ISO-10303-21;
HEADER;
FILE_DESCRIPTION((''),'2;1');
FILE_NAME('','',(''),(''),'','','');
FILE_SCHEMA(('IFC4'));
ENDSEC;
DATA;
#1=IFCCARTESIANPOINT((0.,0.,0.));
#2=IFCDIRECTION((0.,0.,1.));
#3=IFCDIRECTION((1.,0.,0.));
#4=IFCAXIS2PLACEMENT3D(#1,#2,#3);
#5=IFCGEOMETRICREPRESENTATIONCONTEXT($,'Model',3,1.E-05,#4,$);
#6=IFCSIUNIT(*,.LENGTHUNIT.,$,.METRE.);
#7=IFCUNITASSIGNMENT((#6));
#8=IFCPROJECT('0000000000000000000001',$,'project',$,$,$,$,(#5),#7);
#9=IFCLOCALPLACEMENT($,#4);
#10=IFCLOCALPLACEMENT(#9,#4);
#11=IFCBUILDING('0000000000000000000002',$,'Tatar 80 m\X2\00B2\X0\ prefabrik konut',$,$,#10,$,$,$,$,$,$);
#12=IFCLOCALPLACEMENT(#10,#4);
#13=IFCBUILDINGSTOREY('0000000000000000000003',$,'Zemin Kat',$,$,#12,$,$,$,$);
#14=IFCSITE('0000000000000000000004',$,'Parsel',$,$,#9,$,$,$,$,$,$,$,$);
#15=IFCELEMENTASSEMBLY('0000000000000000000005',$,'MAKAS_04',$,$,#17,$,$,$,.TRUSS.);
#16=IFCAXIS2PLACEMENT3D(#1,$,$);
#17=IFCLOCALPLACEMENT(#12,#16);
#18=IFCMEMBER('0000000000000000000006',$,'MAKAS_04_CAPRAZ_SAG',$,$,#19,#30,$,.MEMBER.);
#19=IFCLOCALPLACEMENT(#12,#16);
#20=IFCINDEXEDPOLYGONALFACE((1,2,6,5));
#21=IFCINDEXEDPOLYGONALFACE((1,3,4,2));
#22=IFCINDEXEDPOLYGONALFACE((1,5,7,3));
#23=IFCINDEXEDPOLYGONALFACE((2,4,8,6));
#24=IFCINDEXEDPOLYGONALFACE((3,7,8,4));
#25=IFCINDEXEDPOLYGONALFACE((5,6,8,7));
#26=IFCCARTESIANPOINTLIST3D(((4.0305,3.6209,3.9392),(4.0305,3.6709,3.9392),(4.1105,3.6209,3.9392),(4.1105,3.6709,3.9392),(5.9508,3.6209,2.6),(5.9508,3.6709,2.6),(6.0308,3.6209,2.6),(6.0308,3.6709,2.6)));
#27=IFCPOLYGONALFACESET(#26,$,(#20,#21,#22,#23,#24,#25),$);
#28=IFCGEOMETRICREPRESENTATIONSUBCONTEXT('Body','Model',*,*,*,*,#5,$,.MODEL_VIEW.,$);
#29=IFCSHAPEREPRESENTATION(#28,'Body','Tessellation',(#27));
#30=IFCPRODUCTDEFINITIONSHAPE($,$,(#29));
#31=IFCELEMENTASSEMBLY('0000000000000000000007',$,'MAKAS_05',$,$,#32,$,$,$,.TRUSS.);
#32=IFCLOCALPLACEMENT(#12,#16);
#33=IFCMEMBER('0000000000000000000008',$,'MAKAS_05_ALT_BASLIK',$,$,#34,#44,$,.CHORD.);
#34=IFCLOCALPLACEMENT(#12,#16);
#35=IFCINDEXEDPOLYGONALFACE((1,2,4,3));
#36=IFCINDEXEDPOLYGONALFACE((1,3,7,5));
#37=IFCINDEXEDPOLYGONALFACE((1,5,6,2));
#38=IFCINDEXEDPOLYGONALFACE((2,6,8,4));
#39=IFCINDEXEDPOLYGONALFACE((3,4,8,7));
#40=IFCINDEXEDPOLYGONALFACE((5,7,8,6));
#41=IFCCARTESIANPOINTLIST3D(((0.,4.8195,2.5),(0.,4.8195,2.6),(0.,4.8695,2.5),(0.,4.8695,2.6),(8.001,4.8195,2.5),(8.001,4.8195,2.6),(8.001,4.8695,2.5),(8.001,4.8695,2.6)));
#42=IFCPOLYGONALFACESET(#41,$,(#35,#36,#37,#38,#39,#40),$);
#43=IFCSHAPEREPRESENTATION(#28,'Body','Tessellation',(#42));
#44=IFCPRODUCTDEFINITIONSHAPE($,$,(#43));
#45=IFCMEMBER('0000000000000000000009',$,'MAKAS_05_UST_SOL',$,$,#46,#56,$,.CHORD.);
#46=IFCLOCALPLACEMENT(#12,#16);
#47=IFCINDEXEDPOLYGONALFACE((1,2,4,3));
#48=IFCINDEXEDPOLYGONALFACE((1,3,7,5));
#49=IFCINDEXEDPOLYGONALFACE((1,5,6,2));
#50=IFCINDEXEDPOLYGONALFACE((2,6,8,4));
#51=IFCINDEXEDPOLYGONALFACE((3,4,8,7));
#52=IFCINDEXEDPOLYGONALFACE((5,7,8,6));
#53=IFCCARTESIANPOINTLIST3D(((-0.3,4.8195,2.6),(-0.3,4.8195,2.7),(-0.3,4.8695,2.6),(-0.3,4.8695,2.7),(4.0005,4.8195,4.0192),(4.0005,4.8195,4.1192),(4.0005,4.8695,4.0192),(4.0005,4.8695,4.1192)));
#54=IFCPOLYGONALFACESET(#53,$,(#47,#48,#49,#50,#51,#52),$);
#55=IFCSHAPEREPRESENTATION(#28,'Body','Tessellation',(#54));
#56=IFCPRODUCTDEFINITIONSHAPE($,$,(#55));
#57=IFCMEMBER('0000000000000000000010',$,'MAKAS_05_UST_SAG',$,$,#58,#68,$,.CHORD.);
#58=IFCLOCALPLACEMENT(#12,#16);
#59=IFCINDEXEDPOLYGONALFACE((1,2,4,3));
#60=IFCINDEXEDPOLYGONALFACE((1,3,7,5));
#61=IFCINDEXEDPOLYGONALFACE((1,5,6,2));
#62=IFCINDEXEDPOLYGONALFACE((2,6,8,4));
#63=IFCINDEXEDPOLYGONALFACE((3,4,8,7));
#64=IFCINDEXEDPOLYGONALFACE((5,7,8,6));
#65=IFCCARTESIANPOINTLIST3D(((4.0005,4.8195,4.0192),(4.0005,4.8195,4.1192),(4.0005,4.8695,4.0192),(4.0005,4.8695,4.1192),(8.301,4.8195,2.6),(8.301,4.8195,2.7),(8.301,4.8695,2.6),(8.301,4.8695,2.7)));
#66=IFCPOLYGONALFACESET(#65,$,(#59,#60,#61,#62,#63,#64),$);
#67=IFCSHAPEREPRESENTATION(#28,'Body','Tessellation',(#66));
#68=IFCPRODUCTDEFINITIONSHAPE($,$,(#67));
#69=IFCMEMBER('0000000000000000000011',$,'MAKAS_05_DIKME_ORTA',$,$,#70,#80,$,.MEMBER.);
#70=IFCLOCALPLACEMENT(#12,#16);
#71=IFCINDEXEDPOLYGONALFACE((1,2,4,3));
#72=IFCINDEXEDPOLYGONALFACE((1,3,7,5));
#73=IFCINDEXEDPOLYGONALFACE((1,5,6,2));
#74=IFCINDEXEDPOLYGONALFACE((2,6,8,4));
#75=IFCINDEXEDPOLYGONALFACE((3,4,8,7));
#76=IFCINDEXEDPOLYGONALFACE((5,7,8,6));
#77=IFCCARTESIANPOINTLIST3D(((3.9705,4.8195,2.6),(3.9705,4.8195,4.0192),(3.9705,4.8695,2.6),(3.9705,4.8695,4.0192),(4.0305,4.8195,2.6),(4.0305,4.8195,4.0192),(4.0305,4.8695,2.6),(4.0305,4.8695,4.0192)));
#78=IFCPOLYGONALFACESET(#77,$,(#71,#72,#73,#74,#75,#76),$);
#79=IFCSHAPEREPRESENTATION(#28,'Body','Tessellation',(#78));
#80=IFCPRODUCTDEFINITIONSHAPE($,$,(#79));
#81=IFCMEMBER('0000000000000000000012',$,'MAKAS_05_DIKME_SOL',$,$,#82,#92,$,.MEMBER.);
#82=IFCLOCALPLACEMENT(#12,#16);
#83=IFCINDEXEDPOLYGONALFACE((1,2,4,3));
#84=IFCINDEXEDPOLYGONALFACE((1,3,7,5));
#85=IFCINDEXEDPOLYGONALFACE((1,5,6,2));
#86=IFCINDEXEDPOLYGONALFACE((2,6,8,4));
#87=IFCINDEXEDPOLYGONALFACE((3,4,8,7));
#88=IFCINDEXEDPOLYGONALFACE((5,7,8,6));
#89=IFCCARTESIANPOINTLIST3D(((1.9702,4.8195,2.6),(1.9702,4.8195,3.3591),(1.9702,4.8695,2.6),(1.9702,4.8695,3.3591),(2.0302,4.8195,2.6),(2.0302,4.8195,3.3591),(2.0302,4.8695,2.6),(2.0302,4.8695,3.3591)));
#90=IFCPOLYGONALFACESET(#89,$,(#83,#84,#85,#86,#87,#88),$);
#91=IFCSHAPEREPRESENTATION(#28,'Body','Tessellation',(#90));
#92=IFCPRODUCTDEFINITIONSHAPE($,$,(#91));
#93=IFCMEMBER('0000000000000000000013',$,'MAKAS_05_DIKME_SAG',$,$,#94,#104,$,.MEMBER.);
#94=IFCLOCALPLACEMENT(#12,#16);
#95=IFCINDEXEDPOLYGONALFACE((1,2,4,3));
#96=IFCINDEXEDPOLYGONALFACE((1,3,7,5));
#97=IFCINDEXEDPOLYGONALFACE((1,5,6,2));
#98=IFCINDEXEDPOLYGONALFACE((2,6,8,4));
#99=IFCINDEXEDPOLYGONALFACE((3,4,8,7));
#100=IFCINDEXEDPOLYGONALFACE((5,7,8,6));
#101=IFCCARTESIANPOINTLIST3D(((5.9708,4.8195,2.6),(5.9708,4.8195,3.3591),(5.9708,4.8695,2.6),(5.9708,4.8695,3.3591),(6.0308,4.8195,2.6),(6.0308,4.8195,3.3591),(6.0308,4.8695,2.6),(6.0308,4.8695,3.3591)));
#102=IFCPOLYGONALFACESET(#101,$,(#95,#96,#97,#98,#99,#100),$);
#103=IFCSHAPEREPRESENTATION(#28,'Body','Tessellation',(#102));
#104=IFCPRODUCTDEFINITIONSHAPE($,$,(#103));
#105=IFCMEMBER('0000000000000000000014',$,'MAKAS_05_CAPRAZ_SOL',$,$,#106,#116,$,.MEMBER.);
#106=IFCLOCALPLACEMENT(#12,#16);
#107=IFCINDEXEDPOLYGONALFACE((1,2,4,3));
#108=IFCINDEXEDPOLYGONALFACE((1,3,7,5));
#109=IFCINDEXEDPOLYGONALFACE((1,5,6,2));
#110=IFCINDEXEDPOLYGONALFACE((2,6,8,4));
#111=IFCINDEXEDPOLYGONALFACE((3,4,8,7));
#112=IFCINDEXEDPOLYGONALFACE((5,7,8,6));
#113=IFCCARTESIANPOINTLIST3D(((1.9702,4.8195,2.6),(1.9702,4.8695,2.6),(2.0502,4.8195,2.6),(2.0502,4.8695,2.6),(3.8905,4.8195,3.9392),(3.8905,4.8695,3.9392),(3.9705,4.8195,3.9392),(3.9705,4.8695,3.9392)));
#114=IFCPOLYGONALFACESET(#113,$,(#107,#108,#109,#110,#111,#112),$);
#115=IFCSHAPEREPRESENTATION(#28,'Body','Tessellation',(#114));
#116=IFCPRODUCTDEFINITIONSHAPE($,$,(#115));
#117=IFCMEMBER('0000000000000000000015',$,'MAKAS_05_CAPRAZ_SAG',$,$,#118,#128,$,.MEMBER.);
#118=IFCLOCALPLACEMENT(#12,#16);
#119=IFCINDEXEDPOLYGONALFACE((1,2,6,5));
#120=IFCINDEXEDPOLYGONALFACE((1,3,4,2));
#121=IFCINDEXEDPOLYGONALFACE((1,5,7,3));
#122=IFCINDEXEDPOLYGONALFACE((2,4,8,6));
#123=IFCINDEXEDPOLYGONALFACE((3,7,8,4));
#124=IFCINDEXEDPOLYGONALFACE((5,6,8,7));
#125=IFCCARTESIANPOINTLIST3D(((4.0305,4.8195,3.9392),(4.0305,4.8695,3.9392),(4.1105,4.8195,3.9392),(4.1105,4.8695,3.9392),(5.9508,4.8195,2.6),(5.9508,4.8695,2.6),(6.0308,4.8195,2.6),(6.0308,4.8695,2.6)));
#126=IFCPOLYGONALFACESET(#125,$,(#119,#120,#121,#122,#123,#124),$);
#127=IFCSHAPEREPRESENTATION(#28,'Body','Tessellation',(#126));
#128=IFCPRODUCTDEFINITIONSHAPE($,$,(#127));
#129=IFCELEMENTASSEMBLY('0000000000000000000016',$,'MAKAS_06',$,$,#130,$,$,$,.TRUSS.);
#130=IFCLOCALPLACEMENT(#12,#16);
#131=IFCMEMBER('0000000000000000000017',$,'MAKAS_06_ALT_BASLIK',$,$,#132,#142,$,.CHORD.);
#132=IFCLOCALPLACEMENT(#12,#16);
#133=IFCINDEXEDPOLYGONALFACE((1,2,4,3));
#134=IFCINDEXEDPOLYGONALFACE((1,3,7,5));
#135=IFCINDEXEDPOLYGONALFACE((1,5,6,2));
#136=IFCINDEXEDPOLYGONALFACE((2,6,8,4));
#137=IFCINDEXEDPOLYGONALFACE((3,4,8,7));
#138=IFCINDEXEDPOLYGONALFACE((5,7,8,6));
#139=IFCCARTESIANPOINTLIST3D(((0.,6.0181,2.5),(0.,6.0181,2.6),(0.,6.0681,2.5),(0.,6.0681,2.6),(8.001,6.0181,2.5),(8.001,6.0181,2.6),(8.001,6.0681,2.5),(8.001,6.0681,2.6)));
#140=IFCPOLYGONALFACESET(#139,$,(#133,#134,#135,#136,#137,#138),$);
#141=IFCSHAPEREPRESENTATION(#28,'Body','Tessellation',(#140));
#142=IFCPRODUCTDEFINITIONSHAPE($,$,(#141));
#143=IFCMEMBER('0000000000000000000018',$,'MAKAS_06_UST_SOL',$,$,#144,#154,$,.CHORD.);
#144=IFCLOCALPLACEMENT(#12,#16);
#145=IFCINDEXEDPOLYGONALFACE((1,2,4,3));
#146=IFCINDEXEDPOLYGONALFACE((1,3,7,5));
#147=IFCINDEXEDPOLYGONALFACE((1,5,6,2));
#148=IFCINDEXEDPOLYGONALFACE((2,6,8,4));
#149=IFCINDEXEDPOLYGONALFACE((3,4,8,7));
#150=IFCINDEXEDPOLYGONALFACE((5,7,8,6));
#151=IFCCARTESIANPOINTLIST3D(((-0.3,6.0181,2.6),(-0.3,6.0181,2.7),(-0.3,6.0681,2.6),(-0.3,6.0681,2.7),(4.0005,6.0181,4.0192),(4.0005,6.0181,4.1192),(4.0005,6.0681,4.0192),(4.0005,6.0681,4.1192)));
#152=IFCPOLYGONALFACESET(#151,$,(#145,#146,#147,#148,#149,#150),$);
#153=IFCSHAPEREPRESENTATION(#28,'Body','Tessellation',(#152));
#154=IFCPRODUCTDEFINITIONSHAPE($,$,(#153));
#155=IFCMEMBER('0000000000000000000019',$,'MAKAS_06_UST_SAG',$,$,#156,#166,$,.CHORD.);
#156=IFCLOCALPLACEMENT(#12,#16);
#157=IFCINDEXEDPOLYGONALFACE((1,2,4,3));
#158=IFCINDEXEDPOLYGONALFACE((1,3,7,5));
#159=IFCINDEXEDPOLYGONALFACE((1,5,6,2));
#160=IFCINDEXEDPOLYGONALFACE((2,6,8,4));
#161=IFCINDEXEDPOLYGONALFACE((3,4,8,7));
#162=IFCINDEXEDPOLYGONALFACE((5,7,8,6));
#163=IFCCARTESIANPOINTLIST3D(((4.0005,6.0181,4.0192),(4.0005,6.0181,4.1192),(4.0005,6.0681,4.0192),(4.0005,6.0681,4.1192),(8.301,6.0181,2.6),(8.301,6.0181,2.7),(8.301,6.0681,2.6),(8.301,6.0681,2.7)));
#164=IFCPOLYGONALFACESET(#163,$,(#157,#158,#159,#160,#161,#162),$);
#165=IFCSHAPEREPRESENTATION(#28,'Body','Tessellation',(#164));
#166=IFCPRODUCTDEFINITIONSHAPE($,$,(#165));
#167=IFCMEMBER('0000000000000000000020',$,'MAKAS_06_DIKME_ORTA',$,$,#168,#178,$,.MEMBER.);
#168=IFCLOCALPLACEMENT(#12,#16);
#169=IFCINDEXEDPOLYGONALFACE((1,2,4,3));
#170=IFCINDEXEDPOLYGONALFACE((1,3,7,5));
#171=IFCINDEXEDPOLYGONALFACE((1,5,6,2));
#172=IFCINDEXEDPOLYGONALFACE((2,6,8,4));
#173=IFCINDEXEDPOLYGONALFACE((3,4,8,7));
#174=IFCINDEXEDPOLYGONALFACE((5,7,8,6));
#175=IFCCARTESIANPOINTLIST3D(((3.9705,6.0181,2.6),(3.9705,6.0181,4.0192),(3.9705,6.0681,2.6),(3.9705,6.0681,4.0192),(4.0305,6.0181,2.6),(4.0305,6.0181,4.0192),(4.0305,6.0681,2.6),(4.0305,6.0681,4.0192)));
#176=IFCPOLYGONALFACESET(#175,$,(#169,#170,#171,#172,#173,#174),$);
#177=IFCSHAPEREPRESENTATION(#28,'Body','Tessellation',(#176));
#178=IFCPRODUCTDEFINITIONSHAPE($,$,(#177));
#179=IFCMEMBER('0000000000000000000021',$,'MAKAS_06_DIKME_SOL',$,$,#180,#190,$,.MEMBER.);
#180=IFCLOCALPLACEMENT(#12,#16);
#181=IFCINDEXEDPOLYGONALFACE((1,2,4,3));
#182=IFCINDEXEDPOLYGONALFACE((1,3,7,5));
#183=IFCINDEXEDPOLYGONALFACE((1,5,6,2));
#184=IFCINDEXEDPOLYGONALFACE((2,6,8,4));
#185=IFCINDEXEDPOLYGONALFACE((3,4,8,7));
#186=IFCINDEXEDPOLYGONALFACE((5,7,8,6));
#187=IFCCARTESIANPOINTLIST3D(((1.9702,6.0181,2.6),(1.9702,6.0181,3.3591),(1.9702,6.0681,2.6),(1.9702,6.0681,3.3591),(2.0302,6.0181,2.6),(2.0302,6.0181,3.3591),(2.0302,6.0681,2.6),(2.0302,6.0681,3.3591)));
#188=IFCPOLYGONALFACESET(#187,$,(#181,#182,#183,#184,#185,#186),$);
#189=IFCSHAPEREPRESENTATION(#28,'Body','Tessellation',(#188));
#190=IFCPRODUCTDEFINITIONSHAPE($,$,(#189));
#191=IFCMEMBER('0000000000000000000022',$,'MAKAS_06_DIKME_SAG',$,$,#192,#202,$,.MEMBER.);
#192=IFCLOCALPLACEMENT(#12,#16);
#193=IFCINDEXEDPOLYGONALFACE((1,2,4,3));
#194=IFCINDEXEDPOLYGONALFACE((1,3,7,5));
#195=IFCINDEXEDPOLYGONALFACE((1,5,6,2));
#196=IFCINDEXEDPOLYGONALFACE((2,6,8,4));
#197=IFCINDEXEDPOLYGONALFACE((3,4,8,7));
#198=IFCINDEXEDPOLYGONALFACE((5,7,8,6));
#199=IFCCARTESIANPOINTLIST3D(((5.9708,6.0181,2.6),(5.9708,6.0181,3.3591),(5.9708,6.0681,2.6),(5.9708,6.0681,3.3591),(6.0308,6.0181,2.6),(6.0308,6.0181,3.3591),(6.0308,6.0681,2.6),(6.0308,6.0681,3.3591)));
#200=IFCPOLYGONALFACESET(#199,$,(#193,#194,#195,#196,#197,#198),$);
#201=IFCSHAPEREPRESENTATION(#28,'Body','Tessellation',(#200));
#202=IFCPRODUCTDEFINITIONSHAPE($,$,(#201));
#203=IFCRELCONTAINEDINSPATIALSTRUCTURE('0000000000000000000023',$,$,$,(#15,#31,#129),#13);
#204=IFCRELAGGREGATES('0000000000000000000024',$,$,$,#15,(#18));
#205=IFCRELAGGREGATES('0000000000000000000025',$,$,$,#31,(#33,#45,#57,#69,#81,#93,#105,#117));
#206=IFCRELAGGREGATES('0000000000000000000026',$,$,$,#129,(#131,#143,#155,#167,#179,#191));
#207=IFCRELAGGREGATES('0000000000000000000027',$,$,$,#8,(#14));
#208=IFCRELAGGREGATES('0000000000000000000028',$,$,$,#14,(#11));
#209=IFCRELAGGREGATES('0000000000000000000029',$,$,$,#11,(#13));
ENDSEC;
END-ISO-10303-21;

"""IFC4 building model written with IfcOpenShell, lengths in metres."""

from ifc_helpers import new_model, si_unit, frame, origin_with_axes, place, context, subcontext, project, spatial, line, indexed_curve, outline, extrude, element, aggregate, save


model = new_model("IFC4")

# Units and contexts
model_context = context("Model", 3, precision=1e-05, world=origin_with_axes())
body_context = subcontext(model_context, "Body", "Model", "MODEL_VIEW")
ifc_project = project(units=[si_unit("LENGTHUNIT", "METRE")], contexts=[model_context])

# Site, building, storey
site_placement = place(None, origin_with_axes())
site = spatial("IfcSite", under=ifc_project, at=site_placement, Name="Parsel")
building_placement = place(site_placement, origin_with_axes())
building = spatial("IfcBuilding", under=site, at=building_placement, Name="Tatar 80 m² prefabrik konut")
storey_placement = place(building_placement, origin_with_axes())
storey = spatial("IfcBuildingStorey", under=building, at=storey_placement, Name="Zemin Kat")

# Element assembly, member
assembly_1_placement = place(storey_placement, origin_with_axes())
assembly_1 = element("IfcElementAssembly", 1, at=assembly_1_placement, inside=storey, Name="MAKAS_04", PredefinedType="TRUSS")
member_1_placement = place(assembly_1_placement, origin_with_axes())
member_1 = element("IfcMember", 2, at=member_1_placement, Name="MAKAS_04_CAPRAZ_SAG", PredefinedType="MEMBER", context=body_context, shape_type="SweptSolid", body=[
    extrude(outline(indexed_curve([(5.9508, 2.6), (6.0308, 2.6), (4.1105, 3.9392), (4.0305, 3.9392)], segments=[line(1, 2, 3, 4, 1)])), frame((0.0, 3.6709, 0.0), z_axis=(0.0, -1.0, 0.0), x_axis=(1.0, 0.0, 0.0)), (0.0, 0.0, 1.0), 0.05),
])
aggregate(assembly_1, [member_1])

# Element assemblies, members
assembly_2_placement = place(storey_placement, origin_with_axes())
assembly_2 = element("IfcElementAssembly", 3, at=assembly_2_placement, inside=storey, Name="MAKAS_05", PredefinedType="TRUSS")
member_2_placement = place(assembly_2_placement, origin_with_axes())
member_2 = element("IfcMember", 4, at=member_2_placement, Name="MAKAS_05_ALT_BASLIK", PredefinedType="CHORD", context=body_context, shape_type="SweptSolid", body=[
    extrude(outline(indexed_curve([(0.0, 2.5), (8.001, 2.5), (8.001, 2.6), (0.0, 2.6)], segments=[line(1, 2, 3, 4, 1)])), frame((0.0, 4.8695, 0.0), z_axis=(0.0, -1.0, 0.0), x_axis=(1.0, 0.0, 0.0)), (0.0, 0.0, 1.0), 0.05),
])
member_3_placement = place(assembly_2_placement, origin_with_axes())
member_3 = element("IfcMember", 5, at=member_3_placement, Name="MAKAS_05_UST_SOL", PredefinedType="CHORD", context=body_context, shape_type="SweptSolid", body=[
    extrude(outline(indexed_curve([(-0.3, 2.6), (4.0005, 4.0192), (4.0005, 4.1192), (-0.3, 2.7)], segments=[line(1, 2, 3, 4, 1)])), frame((0.0, 4.8695, 0.0), z_axis=(0.0, -1.0, 0.0), x_axis=(1.0, 0.0, 0.0)), (0.0, 0.0, 1.0), 0.05),
])
member_4_placement = place(assembly_2_placement, origin_with_axes())
member_4 = element("IfcMember", 6, at=member_4_placement, Name="MAKAS_05_UST_SAG", PredefinedType="CHORD", context=body_context, shape_type="SweptSolid", body=[
    extrude(outline(indexed_curve([(4.0005, 4.0192), (8.301, 2.6), (8.301, 2.7), (4.0005, 4.1192)], segments=[line(1, 2, 3, 4, 1)])), frame((0.0, 4.8695, 0.0), z_axis=(0.0, -1.0, 0.0), x_axis=(1.0, 0.0, 0.0)), (0.0, 0.0, 1.0), 0.05),
])
member_5_placement = place(assembly_2_placement, origin_with_axes())
member_5 = element("IfcMember", 7, at=member_5_placement, Name="MAKAS_05_DIKME_ORTA", PredefinedType="MEMBER", context=body_context, shape_type="SweptSolid", body=[
    extrude(outline(indexed_curve([(3.9705, 2.6), (4.0305, 2.6), (4.0305, 4.0192), (3.9705, 4.0192)], segments=[line(1, 2, 3, 4, 1)])), frame((0.0, 4.8695, 0.0), z_axis=(0.0, -1.0, 0.0), x_axis=(1.0, 0.0, 0.0)), (0.0, 0.0, 1.0), 0.05),
])
member_6_placement = place(assembly_2_placement, origin_with_axes())
member_6 = element("IfcMember", 8, at=member_6_placement, Name="MAKAS_05_DIKME_SOL", PredefinedType="MEMBER", context=body_context, shape_type="SweptSolid", body=[
    extrude(outline(indexed_curve([(1.9703, 2.6), (2.0303, 2.6), (2.0303, 3.3591), (1.9703, 3.3591)], segments=[line(1, 2, 3, 4, 1)])), frame((0.0, 4.8695, 0.0), z_axis=(0.0, -1.0, 0.0), x_axis=(1.0, 0.0, 0.0)), (0.0, 0.0, 1.0), 0.05),
])
member_7_placement = place(assembly_2_placement, origin_with_axes())
member_7 = element("IfcMember", 9, at=member_7_placement, Name="MAKAS_05_DIKME_SAG", PredefinedType="MEMBER", context=body_context, shape_type="SweptSolid", body=[
    extrude(outline(indexed_curve([(5.9708, 2.6), (6.0308, 2.6), (6.0308, 3.3591), (5.9708, 3.3591)], segments=[line(1, 2, 3, 4, 1)])), frame((0.0, 4.8695, 0.0), z_axis=(0.0, -1.0, 0.0), x_axis=(1.0, 0.0, 0.0)), (0.0, 0.0, 1.0), 0.05),
])
member_8_placement = place(assembly_2_placement, origin_with_axes())
member_8 = element("IfcMember", 10, at=member_8_placement, Name="MAKAS_05_CAPRAZ_SOL", PredefinedType="MEMBER", context=body_context, shape_type="SweptSolid", body=[
    extrude(outline(indexed_curve([(1.9703, 2.6), (2.0503, 2.6), (3.9705, 3.9392), (3.8905, 3.9392)], segments=[line(1, 2, 3, 4, 1)])), frame((0.0, 4.8695, 0.0), z_axis=(0.0, -1.0, 0.0), x_axis=(1.0, 0.0, 0.0)), (0.0, 0.0, 1.0), 0.05),
])
member_9_placement = place(assembly_2_placement, origin_with_axes())
member_9 = element("IfcMember", 11, at=member_9_placement, Name="MAKAS_05_CAPRAZ_SAG", PredefinedType="MEMBER", context=body_context, shape_type="SweptSolid", body=[
    extrude(outline(indexed_curve([(5.9508, 2.6), (6.0308, 2.6), (4.1105, 3.9392), (4.0305, 3.9392)], segments=[line(1, 2, 3, 4, 1)])), frame((0.0, 4.8695, 0.0), z_axis=(0.0, -1.0, 0.0), x_axis=(1.0, 0.0, 0.0)), (0.0, 0.0, 1.0), 0.05),
])
aggregate(assembly_2, [member_2, member_3, member_4, member_5, member_6, member_7, member_8, member_9])
assembly_3_placement = place(storey_placement, origin_with_axes())
assembly_3 = element("IfcElementAssembly", 12, at=assembly_3_placement, inside=storey, Name="MAKAS_06", PredefinedType="TRUSS")
member_10_placement = place(assembly_3_placement, origin_with_axes())
member_10 = element("IfcMember", 13, at=member_10_placement, Name="MAKAS_06_ALT_BASLIK", PredefinedType="CHORD", context=body_context, shape_type="SweptSolid", body=[
    extrude(outline(indexed_curve([(0.0, 2.5), (8.001, 2.5), (8.001, 2.6), (0.0, 2.6)], segments=[line(1, 2, 3, 4, 1)])), frame((0.0, 6.0681, 0.0), z_axis=(0.0, -1.0, 0.0), x_axis=(1.0, 0.0, 0.0)), (0.0, 0.0, 1.0), 0.05),
])
member_11_placement = place(assembly_3_placement, origin_with_axes())
member_11 = element("IfcMember", 14, at=member_11_placement, Name="MAKAS_06_UST_SOL", PredefinedType="CHORD", context=body_context, shape_type="SweptSolid", body=[
    extrude(outline(indexed_curve([(-0.3, 2.6), (4.0005, 4.0192), (4.0005, 4.1192), (-0.3, 2.7)], segments=[line(1, 2, 3, 4, 1)])), frame((0.0, 6.0681, 0.0), z_axis=(0.0, -1.0, 0.0), x_axis=(1.0, 0.0, 0.0)), (0.0, 0.0, 1.0), 0.05),
])
member_12_placement = place(assembly_3_placement, origin_with_axes())
member_12 = element("IfcMember", 15, at=member_12_placement, Name="MAKAS_06_UST_SAG", PredefinedType="CHORD", context=body_context, shape_type="SweptSolid", body=[
    extrude(outline(indexed_curve([(4.0005, 4.0192), (8.301, 2.6), (8.301, 2.7), (4.0005, 4.1192)], segments=[line(1, 2, 3, 4, 1)])), frame((0.0, 6.0681, 0.0), z_axis=(0.0, -1.0, 0.0), x_axis=(1.0, 0.0, 0.0)), (0.0, 0.0, 1.0), 0.05),
])
member_13_placement = place(assembly_3_placement, origin_with_axes())
member_13 = element("IfcMember", 16, at=member_13_placement, Name="MAKAS_06_DIKME_ORTA", PredefinedType="MEMBER", context=body_context, shape_type="SweptSolid", body=[
    extrude(outline(indexed_curve([(3.9705, 2.6), (4.0305, 2.6), (4.0305, 4.0192), (3.9705, 4.0192)], segments=[line(1, 2, 3, 4, 1)])), frame((0.0, 6.0681, 0.0), z_axis=(0.0, -1.0, 0.0), x_axis=(1.0, 0.0, 0.0)), (0.0, 0.0, 1.0), 0.05),
])
member_14_placement = place(assembly_3_placement, origin_with_axes())
member_14 = element("IfcMember", 17, at=member_14_placement, Name="MAKAS_06_DIKME_SOL", PredefinedType="MEMBER", context=body_context, shape_type="SweptSolid", body=[
    extrude(outline(indexed_curve([(1.9703, 2.6), (2.0303, 2.6), (2.0303, 3.3591), (1.9703, 3.3591)], segments=[line(1, 2, 3, 4, 1)])), frame((0.0, 6.0681, 0.0), z_axis=(0.0, -1.0, 0.0), x_axis=(1.0, 0.0, 0.0)), (0.0, 0.0, 1.0), 0.05),
])
member_15_placement = place(assembly_3_placement, origin_with_axes())
member_15 = element("IfcMember", 18, at=member_15_placement, Name="MAKAS_06_DIKME_SAG", PredefinedType="MEMBER", context=body_context, shape_type="SweptSolid", body=[
    extrude(outline(indexed_curve([(5.9708, 2.6), (6.0308, 2.6), (6.0308, 3.3591), (5.9708, 3.3591)], segments=[line(1, 2, 3, 4, 1)])), frame((0.0, 6.0681, 0.0), z_axis=(0.0, -1.0, 0.0), x_axis=(1.0, 0.0, 0.0)), (0.0, 0.0, 1.0), 0.05),
])
aggregate(assembly_3, [member_10, member_11, member_12, member_13, member_14, member_15])

save(model, "model.ifc")
